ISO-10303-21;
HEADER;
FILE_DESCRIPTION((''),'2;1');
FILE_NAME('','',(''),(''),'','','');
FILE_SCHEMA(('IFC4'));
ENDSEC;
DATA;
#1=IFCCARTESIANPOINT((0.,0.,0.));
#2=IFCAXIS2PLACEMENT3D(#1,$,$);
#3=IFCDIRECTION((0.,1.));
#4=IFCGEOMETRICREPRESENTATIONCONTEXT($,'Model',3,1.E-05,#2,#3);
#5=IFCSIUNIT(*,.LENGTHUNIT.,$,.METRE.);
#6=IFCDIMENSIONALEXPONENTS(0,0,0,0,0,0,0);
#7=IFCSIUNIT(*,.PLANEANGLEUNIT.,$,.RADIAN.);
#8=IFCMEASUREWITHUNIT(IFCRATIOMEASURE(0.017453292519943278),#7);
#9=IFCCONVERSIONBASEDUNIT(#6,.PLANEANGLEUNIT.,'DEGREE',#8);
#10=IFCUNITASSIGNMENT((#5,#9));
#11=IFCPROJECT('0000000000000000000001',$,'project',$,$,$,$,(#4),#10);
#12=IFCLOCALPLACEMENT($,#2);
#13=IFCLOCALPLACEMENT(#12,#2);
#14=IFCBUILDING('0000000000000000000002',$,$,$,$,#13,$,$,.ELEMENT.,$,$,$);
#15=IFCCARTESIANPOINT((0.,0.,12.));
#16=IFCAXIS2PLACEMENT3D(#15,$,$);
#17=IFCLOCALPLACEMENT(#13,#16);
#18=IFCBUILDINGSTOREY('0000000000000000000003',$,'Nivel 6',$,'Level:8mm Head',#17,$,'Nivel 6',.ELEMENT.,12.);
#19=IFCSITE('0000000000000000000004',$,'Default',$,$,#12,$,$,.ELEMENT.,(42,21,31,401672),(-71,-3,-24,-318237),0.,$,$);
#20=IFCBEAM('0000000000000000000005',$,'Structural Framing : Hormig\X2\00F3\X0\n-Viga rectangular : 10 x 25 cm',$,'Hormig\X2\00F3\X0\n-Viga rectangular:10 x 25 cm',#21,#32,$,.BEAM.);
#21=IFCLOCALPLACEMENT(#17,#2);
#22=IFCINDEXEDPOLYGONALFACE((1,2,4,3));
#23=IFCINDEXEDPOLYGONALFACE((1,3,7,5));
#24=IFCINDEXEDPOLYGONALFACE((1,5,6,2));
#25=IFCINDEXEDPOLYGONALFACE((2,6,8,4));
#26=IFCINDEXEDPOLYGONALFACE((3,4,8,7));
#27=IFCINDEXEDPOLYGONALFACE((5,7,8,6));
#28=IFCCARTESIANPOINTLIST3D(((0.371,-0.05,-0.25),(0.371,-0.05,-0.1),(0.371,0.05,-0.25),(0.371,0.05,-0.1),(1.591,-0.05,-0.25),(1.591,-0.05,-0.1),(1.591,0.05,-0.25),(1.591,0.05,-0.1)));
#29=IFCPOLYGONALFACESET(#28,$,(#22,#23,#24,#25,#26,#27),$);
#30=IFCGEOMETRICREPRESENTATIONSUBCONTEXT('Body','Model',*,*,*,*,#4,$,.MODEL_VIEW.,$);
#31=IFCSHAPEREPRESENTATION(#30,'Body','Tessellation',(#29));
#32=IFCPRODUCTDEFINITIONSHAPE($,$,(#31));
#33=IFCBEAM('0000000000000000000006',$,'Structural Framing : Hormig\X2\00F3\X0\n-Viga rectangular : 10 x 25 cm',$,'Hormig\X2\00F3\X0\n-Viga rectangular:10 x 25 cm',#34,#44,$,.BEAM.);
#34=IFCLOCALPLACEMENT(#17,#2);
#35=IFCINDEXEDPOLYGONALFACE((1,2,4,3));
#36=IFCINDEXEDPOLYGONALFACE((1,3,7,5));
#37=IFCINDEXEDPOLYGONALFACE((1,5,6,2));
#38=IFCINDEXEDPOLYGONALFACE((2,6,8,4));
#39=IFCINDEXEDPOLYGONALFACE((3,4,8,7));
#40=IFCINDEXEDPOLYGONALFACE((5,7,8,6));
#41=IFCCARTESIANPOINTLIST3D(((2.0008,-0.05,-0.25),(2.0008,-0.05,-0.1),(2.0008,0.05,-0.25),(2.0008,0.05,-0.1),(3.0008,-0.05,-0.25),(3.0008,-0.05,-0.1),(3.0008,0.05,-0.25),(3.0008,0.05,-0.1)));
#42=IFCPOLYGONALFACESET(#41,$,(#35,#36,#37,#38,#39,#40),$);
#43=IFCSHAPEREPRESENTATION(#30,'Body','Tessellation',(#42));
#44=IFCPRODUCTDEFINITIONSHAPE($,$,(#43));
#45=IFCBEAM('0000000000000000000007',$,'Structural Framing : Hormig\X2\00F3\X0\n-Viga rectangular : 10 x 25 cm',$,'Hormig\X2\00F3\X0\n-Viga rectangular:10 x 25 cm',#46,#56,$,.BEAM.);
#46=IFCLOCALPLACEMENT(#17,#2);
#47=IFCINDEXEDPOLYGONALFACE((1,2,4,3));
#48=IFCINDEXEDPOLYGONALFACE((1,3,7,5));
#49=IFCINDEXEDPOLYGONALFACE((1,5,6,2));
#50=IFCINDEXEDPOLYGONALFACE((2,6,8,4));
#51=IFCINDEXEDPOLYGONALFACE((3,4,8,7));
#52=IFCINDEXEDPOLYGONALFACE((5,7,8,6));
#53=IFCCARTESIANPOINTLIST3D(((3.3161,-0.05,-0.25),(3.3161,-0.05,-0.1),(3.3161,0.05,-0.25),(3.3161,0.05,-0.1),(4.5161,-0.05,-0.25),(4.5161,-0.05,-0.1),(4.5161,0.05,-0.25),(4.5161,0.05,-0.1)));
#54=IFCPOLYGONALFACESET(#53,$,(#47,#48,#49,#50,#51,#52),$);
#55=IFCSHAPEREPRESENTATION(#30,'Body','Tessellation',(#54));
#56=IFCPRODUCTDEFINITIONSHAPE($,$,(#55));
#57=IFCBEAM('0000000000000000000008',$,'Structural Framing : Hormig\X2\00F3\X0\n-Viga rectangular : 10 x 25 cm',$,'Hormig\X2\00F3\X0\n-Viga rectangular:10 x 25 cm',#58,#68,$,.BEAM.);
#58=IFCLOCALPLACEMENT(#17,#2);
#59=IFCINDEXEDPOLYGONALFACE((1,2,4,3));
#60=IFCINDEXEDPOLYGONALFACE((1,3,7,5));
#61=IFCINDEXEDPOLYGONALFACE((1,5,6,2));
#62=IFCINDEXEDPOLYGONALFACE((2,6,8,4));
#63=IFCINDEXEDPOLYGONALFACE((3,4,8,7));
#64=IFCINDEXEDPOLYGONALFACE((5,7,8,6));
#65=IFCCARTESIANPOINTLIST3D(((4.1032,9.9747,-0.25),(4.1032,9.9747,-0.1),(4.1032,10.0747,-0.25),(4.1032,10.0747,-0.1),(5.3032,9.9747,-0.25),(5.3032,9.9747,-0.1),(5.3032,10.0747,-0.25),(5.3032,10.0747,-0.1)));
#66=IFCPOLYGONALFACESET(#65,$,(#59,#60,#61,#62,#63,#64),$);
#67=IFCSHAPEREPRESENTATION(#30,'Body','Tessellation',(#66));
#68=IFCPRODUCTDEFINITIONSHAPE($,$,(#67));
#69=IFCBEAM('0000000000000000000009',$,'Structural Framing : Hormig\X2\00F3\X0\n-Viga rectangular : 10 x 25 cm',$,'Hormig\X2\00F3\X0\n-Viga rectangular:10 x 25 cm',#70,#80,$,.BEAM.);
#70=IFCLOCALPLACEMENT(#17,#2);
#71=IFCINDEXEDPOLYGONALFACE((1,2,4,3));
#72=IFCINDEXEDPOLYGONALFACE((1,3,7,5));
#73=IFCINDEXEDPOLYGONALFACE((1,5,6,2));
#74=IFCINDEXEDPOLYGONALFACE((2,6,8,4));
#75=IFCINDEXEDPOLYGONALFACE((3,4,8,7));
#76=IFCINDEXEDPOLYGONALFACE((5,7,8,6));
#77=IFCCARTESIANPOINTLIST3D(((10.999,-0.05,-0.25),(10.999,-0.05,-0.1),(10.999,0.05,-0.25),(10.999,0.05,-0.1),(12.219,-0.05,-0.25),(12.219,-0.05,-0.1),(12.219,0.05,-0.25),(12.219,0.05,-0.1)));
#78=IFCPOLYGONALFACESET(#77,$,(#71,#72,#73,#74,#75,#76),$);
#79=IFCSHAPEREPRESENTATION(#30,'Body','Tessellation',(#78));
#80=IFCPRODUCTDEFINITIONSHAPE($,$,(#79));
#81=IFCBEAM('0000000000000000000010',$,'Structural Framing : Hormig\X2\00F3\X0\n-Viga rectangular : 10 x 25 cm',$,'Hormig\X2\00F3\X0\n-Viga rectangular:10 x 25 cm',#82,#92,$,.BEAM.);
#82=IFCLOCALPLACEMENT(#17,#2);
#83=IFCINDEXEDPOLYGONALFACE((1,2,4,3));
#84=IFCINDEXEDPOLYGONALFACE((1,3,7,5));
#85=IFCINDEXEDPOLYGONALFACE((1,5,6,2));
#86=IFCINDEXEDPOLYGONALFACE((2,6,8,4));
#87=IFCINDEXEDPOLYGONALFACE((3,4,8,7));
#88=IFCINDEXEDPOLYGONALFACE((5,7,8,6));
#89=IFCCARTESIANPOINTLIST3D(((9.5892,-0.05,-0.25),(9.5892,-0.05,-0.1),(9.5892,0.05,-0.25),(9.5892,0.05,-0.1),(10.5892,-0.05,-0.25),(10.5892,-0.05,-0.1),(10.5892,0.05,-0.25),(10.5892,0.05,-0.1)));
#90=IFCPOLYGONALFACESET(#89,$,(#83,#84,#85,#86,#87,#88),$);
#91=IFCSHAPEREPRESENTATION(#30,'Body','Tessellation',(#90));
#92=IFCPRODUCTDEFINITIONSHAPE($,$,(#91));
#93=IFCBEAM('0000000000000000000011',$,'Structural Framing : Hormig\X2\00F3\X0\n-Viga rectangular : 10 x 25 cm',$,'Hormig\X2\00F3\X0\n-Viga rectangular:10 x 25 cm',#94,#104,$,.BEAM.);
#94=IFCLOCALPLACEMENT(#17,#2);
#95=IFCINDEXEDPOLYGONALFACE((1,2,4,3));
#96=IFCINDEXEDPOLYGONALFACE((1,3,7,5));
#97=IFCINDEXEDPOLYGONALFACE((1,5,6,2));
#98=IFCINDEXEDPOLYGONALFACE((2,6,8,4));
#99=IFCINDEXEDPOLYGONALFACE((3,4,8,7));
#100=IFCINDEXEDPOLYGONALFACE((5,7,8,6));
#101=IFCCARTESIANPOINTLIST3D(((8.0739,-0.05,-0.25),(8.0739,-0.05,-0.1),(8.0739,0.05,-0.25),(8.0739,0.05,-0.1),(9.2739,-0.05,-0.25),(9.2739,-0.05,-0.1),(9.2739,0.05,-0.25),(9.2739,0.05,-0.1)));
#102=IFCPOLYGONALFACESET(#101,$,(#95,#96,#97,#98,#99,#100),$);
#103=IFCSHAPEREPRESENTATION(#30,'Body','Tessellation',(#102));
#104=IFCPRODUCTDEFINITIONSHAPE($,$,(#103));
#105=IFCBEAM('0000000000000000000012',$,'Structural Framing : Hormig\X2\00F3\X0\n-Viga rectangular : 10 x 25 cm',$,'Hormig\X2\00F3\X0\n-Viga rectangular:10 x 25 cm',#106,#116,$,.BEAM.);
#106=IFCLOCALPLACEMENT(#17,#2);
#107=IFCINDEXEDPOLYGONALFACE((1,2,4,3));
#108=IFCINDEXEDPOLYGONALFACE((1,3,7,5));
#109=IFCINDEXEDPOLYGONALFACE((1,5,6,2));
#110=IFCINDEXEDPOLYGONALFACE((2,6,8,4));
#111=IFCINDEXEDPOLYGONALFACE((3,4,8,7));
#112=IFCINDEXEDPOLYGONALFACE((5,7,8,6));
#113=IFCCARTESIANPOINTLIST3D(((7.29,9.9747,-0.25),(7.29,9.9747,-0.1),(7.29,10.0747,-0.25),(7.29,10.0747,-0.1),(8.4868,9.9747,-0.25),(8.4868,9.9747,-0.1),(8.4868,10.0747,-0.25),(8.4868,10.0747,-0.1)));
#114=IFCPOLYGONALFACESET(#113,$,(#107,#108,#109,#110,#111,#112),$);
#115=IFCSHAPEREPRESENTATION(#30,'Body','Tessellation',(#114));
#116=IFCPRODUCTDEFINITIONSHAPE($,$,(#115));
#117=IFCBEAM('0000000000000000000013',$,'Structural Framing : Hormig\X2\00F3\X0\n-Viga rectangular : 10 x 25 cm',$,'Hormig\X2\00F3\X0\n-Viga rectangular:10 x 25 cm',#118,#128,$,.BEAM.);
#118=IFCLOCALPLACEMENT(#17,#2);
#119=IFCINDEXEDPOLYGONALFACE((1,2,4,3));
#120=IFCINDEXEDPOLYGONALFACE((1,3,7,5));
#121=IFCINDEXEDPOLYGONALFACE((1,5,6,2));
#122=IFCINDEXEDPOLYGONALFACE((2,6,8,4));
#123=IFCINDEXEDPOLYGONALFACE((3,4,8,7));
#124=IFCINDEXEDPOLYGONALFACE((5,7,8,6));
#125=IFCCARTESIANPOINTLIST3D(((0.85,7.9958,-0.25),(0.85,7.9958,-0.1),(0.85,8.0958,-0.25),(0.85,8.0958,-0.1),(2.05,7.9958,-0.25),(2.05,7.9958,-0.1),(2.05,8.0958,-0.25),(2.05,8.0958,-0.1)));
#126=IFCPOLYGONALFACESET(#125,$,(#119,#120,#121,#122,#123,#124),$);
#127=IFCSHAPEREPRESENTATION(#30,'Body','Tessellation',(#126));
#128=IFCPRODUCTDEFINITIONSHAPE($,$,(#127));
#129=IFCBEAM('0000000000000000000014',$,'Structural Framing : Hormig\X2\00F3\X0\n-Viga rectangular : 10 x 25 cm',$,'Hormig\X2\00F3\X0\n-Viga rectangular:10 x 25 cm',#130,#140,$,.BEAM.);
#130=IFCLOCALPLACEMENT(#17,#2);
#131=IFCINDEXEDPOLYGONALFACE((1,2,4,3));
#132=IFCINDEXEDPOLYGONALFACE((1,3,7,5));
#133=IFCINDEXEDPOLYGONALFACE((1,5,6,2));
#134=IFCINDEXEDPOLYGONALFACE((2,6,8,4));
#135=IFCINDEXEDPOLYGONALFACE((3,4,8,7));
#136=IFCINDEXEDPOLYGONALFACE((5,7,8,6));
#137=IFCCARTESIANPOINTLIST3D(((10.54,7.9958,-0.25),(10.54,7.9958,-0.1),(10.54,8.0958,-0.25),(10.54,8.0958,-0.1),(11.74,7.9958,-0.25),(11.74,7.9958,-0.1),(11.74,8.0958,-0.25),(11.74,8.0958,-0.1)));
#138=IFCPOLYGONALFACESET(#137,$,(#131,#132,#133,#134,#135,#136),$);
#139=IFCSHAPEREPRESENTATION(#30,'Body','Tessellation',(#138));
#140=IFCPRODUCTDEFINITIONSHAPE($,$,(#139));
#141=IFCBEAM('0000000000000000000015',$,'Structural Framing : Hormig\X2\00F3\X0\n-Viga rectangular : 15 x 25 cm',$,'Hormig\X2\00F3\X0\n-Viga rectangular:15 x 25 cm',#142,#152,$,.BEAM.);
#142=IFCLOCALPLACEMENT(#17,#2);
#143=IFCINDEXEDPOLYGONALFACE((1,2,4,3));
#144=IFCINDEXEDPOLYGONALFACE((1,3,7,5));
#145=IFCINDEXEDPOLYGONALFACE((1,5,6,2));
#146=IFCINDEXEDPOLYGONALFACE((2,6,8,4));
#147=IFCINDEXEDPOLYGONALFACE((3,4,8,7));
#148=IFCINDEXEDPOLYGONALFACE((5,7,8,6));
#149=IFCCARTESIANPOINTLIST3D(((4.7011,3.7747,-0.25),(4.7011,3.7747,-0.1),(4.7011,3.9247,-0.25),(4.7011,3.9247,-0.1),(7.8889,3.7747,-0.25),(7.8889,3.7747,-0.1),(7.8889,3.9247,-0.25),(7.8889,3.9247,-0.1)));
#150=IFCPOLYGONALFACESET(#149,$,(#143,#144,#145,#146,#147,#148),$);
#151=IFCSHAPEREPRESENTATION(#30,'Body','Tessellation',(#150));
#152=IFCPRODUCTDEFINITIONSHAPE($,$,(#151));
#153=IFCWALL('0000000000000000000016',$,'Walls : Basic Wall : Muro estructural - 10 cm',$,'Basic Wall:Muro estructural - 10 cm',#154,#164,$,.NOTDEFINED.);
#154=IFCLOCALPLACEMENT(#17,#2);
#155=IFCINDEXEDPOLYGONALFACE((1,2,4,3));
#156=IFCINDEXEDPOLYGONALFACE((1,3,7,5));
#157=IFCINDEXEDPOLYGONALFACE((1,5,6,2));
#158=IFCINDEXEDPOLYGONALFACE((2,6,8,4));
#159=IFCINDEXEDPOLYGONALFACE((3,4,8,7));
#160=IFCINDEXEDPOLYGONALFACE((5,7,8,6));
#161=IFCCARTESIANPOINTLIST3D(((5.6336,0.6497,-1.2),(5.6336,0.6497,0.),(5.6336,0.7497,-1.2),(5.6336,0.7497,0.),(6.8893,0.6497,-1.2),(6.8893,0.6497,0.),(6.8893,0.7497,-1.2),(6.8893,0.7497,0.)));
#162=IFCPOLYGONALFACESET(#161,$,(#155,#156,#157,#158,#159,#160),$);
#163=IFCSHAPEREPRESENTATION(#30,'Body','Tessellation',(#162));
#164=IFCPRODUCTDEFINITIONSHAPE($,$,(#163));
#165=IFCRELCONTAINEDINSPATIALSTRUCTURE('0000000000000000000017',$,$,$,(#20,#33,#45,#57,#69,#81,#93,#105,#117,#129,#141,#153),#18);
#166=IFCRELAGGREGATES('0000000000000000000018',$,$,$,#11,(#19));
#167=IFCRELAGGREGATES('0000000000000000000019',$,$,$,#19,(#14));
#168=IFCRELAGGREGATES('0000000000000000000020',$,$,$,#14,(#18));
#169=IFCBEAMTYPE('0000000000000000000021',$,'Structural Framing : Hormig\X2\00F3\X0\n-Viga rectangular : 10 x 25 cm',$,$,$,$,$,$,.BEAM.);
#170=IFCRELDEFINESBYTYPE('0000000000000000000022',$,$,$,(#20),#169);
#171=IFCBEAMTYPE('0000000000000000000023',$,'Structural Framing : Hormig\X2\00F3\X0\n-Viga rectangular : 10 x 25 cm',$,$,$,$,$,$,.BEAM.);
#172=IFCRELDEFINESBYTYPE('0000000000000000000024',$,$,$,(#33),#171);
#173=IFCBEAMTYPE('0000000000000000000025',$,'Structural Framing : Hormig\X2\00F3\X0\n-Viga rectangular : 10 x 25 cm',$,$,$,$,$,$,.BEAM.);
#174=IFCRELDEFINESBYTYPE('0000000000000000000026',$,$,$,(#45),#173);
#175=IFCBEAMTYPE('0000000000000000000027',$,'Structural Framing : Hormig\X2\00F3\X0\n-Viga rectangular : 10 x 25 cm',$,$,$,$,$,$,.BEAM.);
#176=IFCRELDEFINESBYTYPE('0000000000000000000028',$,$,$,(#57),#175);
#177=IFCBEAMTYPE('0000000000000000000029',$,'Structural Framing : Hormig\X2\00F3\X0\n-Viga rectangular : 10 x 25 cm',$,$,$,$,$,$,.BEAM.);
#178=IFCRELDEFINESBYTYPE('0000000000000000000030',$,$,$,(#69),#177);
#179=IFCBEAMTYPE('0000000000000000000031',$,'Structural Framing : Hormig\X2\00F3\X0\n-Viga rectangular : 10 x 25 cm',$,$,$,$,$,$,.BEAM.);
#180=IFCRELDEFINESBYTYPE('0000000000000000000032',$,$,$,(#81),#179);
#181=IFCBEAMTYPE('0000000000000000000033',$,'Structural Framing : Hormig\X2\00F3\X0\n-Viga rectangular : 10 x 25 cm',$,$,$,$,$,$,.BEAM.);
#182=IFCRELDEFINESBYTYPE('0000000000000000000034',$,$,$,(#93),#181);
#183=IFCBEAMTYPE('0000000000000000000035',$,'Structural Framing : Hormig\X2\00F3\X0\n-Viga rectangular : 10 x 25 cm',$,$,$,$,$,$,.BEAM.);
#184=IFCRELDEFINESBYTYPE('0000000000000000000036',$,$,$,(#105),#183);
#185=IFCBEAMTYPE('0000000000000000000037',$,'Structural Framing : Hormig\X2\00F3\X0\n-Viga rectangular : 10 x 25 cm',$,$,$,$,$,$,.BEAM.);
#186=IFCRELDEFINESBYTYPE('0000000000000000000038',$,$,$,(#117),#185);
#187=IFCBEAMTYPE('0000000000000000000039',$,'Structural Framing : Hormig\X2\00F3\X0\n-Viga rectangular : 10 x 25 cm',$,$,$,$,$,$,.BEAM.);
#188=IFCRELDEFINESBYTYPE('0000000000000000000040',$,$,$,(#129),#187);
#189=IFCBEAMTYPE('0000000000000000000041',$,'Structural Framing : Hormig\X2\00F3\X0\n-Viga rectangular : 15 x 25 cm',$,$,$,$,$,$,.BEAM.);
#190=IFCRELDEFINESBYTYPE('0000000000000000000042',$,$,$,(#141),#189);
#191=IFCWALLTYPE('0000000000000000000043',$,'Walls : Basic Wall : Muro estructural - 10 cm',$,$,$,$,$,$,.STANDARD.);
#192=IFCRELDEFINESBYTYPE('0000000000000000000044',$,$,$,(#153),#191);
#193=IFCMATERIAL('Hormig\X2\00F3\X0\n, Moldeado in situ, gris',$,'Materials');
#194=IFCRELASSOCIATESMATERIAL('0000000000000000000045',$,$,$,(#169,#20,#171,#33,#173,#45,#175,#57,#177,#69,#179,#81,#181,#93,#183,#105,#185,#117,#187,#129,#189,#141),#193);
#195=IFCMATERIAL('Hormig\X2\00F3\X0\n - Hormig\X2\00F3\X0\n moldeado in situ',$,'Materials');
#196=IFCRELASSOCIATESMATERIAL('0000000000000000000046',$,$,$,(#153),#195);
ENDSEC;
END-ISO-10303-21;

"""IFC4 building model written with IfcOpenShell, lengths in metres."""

from ifc_helpers import new_model, entity, si_unit, converted_unit, direction, frame, origin, place, context, subcontext, project, spatial, indexed_curve, outline, extrude, source, transform, mapped, material, type_object, type_shapes, element, save


model = new_model("IFC4")

# Units and contexts
model_context = context("Model", 3, precision=1e-05, world=origin(), true_north=direction((0.0, 1.0)))
body_context = subcontext(model_context, "Body", "Model", "MODEL_VIEW")
ifc_project = project(units=[si_unit("LENGTHUNIT", "METRE"), converted_unit("PLANEANGLEUNIT", "DEGREE", entity("IfcRatioMeasure", 0.017453292519943278), si_unit("PLANEANGLEUNIT", "RADIAN"), dimensions=[0, 0, 0, 0, 0, 0, 0])], contexts=[model_context])

# Site, building, storey
site_placement = place(None, origin())
site = spatial("IfcSite", under=ifc_project, at=site_placement, Name="Default", CompositionType="ELEMENT", RefLatitude=(42, 21, 31, 401672), RefLongitude=(-71, -3, -24, -318237), RefElevation=0.0)
building_placement = place(site_placement, origin())
building = spatial("IfcBuilding", under=site, at=building_placement, CompositionType="ELEMENT")
storey_placement = place(building_placement, frame((0.0, 0.0, 12.0)))
storey = spatial("IfcBuildingStorey", under=building, at=storey_placement, Name="Nivel 6", ObjectType="Level:8mm Head", LongName="Nivel 6", CompositionType="ELEMENT", Elevation=12.0)

# Beams
ifc_material_1 = material(Name="Hormigón, Moldeado in situ, gris", Category="Materials")
beam_type_1 = type_object("IfcBeamType", Name="Structural Framing : Hormigón-Viga rectangular : 10 x 25 cm", PredefinedType="BEAM", material=ifc_material_1)
shared_shape_1 = source(origin(), body_context, "Body", "SweptSolid", [
    extrude(outline(indexed_curve([(-0.075, -0.05), (0.075, -0.05), (0.075, 0.05), (-0.075, 0.05), (-0.075, -0.05)], self_intersect=False)), frame((0.371, 0.0, 11.825), z_axis=(1.0, 0.0, 0.0), x_axis=(0.0, 0.0, -1.0)), (0.0, 0.0, 1.0), 1.22),
])
type_shapes(beam_type_1, [shared_shape_1])
beam_1_placement = place(storey_placement, frame((0.0, 0.0, -12.0)))
element("IfcBeam", 1, at=beam_1_placement, inside=storey, type_object=beam_type_1, material=ifc_material_1, Name="Structural Framing : Hormigón-Viga rectangular : 10 x 25 cm", ObjectType="Hormigón-Viga rectangular:10 x 25 cm", PredefinedType="BEAM", context=body_context, shape_type="MappedRepresentation", body=[
    mapped(shared_shape_1, transform((0.0, 0.0, 0.0), scale=1.0)),
])
beam_type_2 = type_object("IfcBeamType", Name="Structural Framing : Hormigón-Viga rectangular : 10 x 25 cm", PredefinedType="BEAM", material=ifc_material_1)
shared_shape_2 = source(origin(), body_context, "Body", "SweptSolid", [
    extrude(outline(indexed_curve([(-0.075, -0.05), (0.075, -0.05), (0.075, 0.05), (-0.075, 0.05), (-0.075, -0.05)], self_intersect=False)), frame((2.0008, 0.0, 11.825), z_axis=(1.0, 0.0, 0.0), x_axis=(0.0, 0.0, -1.0)), (0.0, 0.0, 1.0), 1.0),
])
type_shapes(beam_type_2, [shared_shape_2])
beam_2_placement = place(storey_placement, frame((0.0, 0.0, -12.0)))
element("IfcBeam", 2, at=beam_2_placement, inside=storey, type_object=beam_type_2, material=ifc_material_1, Name="Structural Framing : Hormigón-Viga rectangular : 10 x 25 cm", ObjectType="Hormigón-Viga rectangular:10 x 25 cm", PredefinedType="BEAM", context=body_context, shape_type="MappedRepresentation", body=[
    mapped(shared_shape_2, transform((0.0, 0.0, 0.0), scale=1.0)),
])
beam_type_3 = type_object("IfcBeamType", Name="Structural Framing : Hormigón-Viga rectangular : 10 x 25 cm", PredefinedType="BEAM", material=ifc_material_1)
shared_shape_3 = source(origin(), body_context, "Body", "SweptSolid", [
    extrude(outline(indexed_curve([(-0.075, -0.05), (0.075, -0.05), (0.075, 0.05), (-0.075, 0.05), (-0.075, -0.05)], self_intersect=False)), frame((3.3161, 0.0, 11.825), z_axis=(1.0, 0.0, 0.0), x_axis=(0.0, 0.0, -1.0)), (0.0, 0.0, 1.0), 1.2),
])
type_shapes(beam_type_3, [shared_shape_3])
beam_3_placement = place(storey_placement, frame((0.0, 0.0, -12.0)))
element("IfcBeam", 3, at=beam_3_placement, inside=storey, type_object=beam_type_3, material=ifc_material_1, Name="Structural Framing : Hormigón-Viga rectangular : 10 x 25 cm", ObjectType="Hormigón-Viga rectangular:10 x 25 cm", PredefinedType="BEAM", context=body_context, shape_type="MappedRepresentation", body=[
    mapped(shared_shape_3, transform((0.0, 0.0, 0.0), scale=1.0)),
])
beam_type_4 = type_object("IfcBeamType", Name="Structural Framing : Hormigón-Viga rectangular : 10 x 25 cm", PredefinedType="BEAM", material=ifc_material_1)
shared_shape_4 = source(origin(), body_context, "Body", "SweptSolid", [
    extrude(outline(indexed_curve([(-0.075, -0.05), (0.075, -0.05), (0.075, 0.05), (-0.075, 0.05), (-0.075, -0.05)], self_intersect=False)), frame((5.3032, 10.0247, 11.825), z_axis=(-1.0, 0.0, 0.0), x_axis=(0.0, 0.0, -1.0)), (0.0, 0.0, 1.0), 1.2),
])
type_shapes(beam_type_4, [shared_shape_4])
beam_4_placement = place(storey_placement, frame((0.0, 0.0, -12.0)))
element("IfcBeam", 4, at=beam_4_placement, inside=storey, type_object=beam_type_4, material=ifc_material_1, Name="Structural Framing : Hormigón-Viga rectangular : 10 x 25 cm", ObjectType="Hormigón-Viga rectangular:10 x 25 cm", PredefinedType="BEAM", context=body_context, shape_type="MappedRepresentation", body=[
    mapped(shared_shape_4, transform((0.0, 0.0, 0.0), scale=1.0)),
])
beam_type_5 = type_object("IfcBeamType", Name="Structural Framing : Hormigón-Viga rectangular : 10 x 25 cm", PredefinedType="BEAM", material=ifc_material_1)
shared_shape_5 = source(origin(), body_context, "Body", "SweptSolid", [
    extrude(outline(indexed_curve([(-0.075, -0.05), (0.075, -0.05), (0.075, 0.05), (-0.075, 0.05), (-0.075, -0.05)], self_intersect=False)), frame((12.219, 0.0, 11.825), z_axis=(-1.0, 0.0, 0.0), x_axis=(0.0, 0.0, -1.0)), (0.0, 0.0, 1.0), 1.22),
])
type_shapes(beam_type_5, [shared_shape_5])
beam_5_placement = place(storey_placement, frame((0.0, 0.0, -12.0)))
element("IfcBeam", 5, at=beam_5_placement, inside=storey, type_object=beam_type_5, material=ifc_material_1, Name="Structural Framing : Hormigón-Viga rectangular : 10 x 25 cm", ObjectType="Hormigón-Viga rectangular:10 x 25 cm", PredefinedType="BEAM", context=body_context, shape_type="MappedRepresentation", body=[
    mapped(shared_shape_5, transform((0.0, 0.0, 0.0), scale=1.0)),
])
beam_type_6 = type_object("IfcBeamType", Name="Structural Framing : Hormigón-Viga rectangular : 10 x 25 cm", PredefinedType="BEAM", material=ifc_material_1)
shared_shape_6 = source(origin(), body_context, "Body", "SweptSolid", [
    extrude(outline(indexed_curve([(-0.075, -0.05), (0.075, -0.05), (0.075, 0.05), (-0.075, 0.05), (-0.075, -0.05)], self_intersect=False)), frame((10.5892, 0.0, 11.825), z_axis=(-1.0, 0.0, 0.0), x_axis=(0.0, 0.0, -1.0)), (0.0, 0.0, 1.0), 1.0),
])
type_shapes(beam_type_6, [shared_shape_6])
beam_6_placement = place(storey_placement, frame((0.0, 0.0, -12.0)))
element("IfcBeam", 6, at=beam_6_placement, inside=storey, type_object=beam_type_6, material=ifc_material_1, Name="Structural Framing : Hormigón-Viga rectangular : 10 x 25 cm", ObjectType="Hormigón-Viga rectangular:10 x 25 cm", PredefinedType="BEAM", context=body_context, shape_type="MappedRepresentation", body=[
    mapped(shared_shape_6, transform((0.0, 0.0, 0.0), scale=1.0)),
])
beam_type_7 = type_object("IfcBeamType", Name="Structural Framing : Hormigón-Viga rectangular : 10 x 25 cm", PredefinedType="BEAM", material=ifc_material_1)
shared_shape_7 = source(origin(), body_context, "Body", "SweptSolid", [
    extrude(outline(indexed_curve([(-0.075, -0.05), (0.075, -0.05), (0.075, 0.05), (-0.075, 0.05), (-0.075, -0.05)], self_intersect=False)), frame((9.2739, 0.0, 11.825), z_axis=(-1.0, 0.0, 0.0), x_axis=(0.0, 0.0, -1.0)), (0.0, 0.0, 1.0), 1.2),
])
type_shapes(beam_type_7, [shared_shape_7])
beam_7_placement = place(storey_placement, frame((0.0, 0.0, -12.0)))
element("IfcBeam", 7, at=beam_7_placement, inside=storey, type_object=beam_type_7, material=ifc_material_1, Name="Structural Framing : Hormigón-Viga rectangular : 10 x 25 cm", ObjectType="Hormigón-Viga rectangular:10 x 25 cm", PredefinedType="BEAM", context=body_context, shape_type="MappedRepresentation", body=[
    mapped(shared_shape_7, transform((0.0, 0.0, 0.0), scale=1.0)),
])
beam_type_8 = type_object("IfcBeamType", Name="Structural Framing : Hormigón-Viga rectangular : 10 x 25 cm", PredefinedType="BEAM", material=ifc_material_1)
shared_shape_8 = source(origin(), body_context, "Body", "SweptSolid", [
    extrude(outline(indexed_curve([(-0.075, -0.05), (0.075, -0.05), (0.075, 0.05), (-0.075, 0.05), (-0.075, -0.05)], self_intersect=False)), frame((7.29, 10.0247, 11.825), z_axis=(1.0, 0.0, 0.0), x_axis=(0.0, 0.0, -1.0)), (0.0, 0.0, 1.0), 1.1968),
])
type_shapes(beam_type_8, [shared_shape_8])
beam_8_placement = place(storey_placement, frame((0.0, 0.0, -12.0)))
element("IfcBeam", 8, at=beam_8_placement, inside=storey, type_object=beam_type_8, material=ifc_material_1, Name="Structural Framing : Hormigón-Viga rectangular : 10 x 25 cm", ObjectType="Hormigón-Viga rectangular:10 x 25 cm", PredefinedType="BEAM", context=body_context, shape_type="MappedRepresentation", body=[
    mapped(shared_shape_8, transform((0.0, 0.0, 0.0), scale=1.0)),
])
beam_type_9 = type_object("IfcBeamType", Name="Structural Framing : Hormigón-Viga rectangular : 10 x 25 cm", PredefinedType="BEAM", material=ifc_material_1)
shared_shape_9 = source(origin(), body_context, "Body", "SweptSolid", [
    extrude(outline(indexed_curve([(-0.075, -0.05), (0.075, -0.05), (0.075, 0.05), (-0.075, 0.05), (-0.075, -0.05)], self_intersect=False)), frame((2.05, 8.0458, 11.825), z_axis=(-1.0, 0.0, 0.0), x_axis=(0.0, 0.0, -1.0)), (0.0, 0.0, 1.0), 1.2),
])
type_shapes(beam_type_9, [shared_shape_9])
beam_9_placement = place(storey_placement, frame((0.0, 0.0, -12.0)))
element("IfcBeam", 9, at=beam_9_placement, inside=storey, type_object=beam_type_9, material=ifc_material_1, Name="Structural Framing : Hormigón-Viga rectangular : 10 x 25 cm", ObjectType="Hormigón-Viga rectangular:10 x 25 cm", PredefinedType="BEAM", context=body_context, shape_type="MappedRepresentation", body=[
    mapped(shared_shape_9, transform((0.0, 0.0, 0.0), scale=1.0)),
])
beam_type_10 = type_object("IfcBeamType", Name="Structural Framing : Hormigón-Viga rectangular : 10 x 25 cm", PredefinedType="BEAM", material=ifc_material_1)
shared_shape_10 = source(origin(), body_context, "Body", "SweptSolid", [
    extrude(outline(indexed_curve([(-0.075, -0.05), (0.075, -0.05), (0.075, 0.05), (-0.075, 0.05), (-0.075, -0.05)], self_intersect=False)), frame((10.54, 8.0458, 11.825), z_axis=(1.0, 0.0, 0.0), x_axis=(0.0, 0.0, -1.0)), (0.0, 0.0, 1.0), 1.2),
])
type_shapes(beam_type_10, [shared_shape_10])
beam_10_placement = place(storey_placement, frame((0.0, 0.0, -12.0)))
element("IfcBeam", 10, at=beam_10_placement, inside=storey, type_object=beam_type_10, material=ifc_material_1, Name="Structural Framing : Hormigón-Viga rectangular : 10 x 25 cm", ObjectType="Hormigón-Viga rectangular:10 x 25 cm", PredefinedType="BEAM", context=body_context, shape_type="MappedRepresentation", body=[
    mapped(shared_shape_10, transform((0.0, 0.0, 0.0), scale=1.0)),
])
beam_type_11 = type_object("IfcBeamType", Name="Structural Framing : Hormigón-Viga rectangular : 15 x 25 cm", PredefinedType="BEAM", material=ifc_material_1)
shared_shape_11 = source(origin(), body_context, "Body", "SweptSolid", [
    extrude(outline(indexed_curve([(-0.075, -0.075), (0.075, -0.075), (0.075, 0.075), (-0.075, 0.075), (-0.075, -0.075)], self_intersect=False)), frame((4.7011, 3.8497, 11.825), z_axis=(1.0, 0.0, 0.0), x_axis=(0.0, 0.0, -1.0)), (0.0, 0.0, 1.0), 3.1878),
])
type_shapes(beam_type_11, [shared_shape_11])
beam_11_placement = place(storey_placement, frame((0.0, 0.0, -12.0)))
element("IfcBeam", 11, at=beam_11_placement, inside=storey, type_object=beam_type_11, material=ifc_material_1, Name="Structural Framing : Hormigón-Viga rectangular : 15 x 25 cm", ObjectType="Hormigón-Viga rectangular:15 x 25 cm", PredefinedType="BEAM", context=body_context, shape_type="MappedRepresentation", body=[
    mapped(shared_shape_11, transform((0.0, 0.0, 0.0), scale=1.0)),
])

# Shared definitions
ifc_material_2 = material(Name="Hormigón - Hormigón moldeado in situ", Category="Materials")

# Wall
wall_type = type_object("IfcWallType", Name="Walls : Basic Wall : Muro estructural - 10 cm", PredefinedType="STANDARD")
wall_placement = place(storey_placement, frame((5.6336, 0.6997, -1.2)))
element("IfcWall", 12, at=wall_placement, inside=storey, type_object=wall_type, material=ifc_material_2, Name="Walls : Basic Wall : Muro estructural - 10 cm", ObjectType="Basic Wall:Muro estructural - 10 cm", PredefinedType="NOTDEFINED", context=body_context, shape_type="SweptSolid", body=[
    extrude(outline(indexed_curve([(1.2557, 0.05), (0.0, 0.05), (0.0, -0.05), (1.2557, -0.05), (1.2557, 0.05)], self_intersect=False)), origin(), (0.0, 0.0, 1.0), 1.2),
])

save(model, "model.ifc")
